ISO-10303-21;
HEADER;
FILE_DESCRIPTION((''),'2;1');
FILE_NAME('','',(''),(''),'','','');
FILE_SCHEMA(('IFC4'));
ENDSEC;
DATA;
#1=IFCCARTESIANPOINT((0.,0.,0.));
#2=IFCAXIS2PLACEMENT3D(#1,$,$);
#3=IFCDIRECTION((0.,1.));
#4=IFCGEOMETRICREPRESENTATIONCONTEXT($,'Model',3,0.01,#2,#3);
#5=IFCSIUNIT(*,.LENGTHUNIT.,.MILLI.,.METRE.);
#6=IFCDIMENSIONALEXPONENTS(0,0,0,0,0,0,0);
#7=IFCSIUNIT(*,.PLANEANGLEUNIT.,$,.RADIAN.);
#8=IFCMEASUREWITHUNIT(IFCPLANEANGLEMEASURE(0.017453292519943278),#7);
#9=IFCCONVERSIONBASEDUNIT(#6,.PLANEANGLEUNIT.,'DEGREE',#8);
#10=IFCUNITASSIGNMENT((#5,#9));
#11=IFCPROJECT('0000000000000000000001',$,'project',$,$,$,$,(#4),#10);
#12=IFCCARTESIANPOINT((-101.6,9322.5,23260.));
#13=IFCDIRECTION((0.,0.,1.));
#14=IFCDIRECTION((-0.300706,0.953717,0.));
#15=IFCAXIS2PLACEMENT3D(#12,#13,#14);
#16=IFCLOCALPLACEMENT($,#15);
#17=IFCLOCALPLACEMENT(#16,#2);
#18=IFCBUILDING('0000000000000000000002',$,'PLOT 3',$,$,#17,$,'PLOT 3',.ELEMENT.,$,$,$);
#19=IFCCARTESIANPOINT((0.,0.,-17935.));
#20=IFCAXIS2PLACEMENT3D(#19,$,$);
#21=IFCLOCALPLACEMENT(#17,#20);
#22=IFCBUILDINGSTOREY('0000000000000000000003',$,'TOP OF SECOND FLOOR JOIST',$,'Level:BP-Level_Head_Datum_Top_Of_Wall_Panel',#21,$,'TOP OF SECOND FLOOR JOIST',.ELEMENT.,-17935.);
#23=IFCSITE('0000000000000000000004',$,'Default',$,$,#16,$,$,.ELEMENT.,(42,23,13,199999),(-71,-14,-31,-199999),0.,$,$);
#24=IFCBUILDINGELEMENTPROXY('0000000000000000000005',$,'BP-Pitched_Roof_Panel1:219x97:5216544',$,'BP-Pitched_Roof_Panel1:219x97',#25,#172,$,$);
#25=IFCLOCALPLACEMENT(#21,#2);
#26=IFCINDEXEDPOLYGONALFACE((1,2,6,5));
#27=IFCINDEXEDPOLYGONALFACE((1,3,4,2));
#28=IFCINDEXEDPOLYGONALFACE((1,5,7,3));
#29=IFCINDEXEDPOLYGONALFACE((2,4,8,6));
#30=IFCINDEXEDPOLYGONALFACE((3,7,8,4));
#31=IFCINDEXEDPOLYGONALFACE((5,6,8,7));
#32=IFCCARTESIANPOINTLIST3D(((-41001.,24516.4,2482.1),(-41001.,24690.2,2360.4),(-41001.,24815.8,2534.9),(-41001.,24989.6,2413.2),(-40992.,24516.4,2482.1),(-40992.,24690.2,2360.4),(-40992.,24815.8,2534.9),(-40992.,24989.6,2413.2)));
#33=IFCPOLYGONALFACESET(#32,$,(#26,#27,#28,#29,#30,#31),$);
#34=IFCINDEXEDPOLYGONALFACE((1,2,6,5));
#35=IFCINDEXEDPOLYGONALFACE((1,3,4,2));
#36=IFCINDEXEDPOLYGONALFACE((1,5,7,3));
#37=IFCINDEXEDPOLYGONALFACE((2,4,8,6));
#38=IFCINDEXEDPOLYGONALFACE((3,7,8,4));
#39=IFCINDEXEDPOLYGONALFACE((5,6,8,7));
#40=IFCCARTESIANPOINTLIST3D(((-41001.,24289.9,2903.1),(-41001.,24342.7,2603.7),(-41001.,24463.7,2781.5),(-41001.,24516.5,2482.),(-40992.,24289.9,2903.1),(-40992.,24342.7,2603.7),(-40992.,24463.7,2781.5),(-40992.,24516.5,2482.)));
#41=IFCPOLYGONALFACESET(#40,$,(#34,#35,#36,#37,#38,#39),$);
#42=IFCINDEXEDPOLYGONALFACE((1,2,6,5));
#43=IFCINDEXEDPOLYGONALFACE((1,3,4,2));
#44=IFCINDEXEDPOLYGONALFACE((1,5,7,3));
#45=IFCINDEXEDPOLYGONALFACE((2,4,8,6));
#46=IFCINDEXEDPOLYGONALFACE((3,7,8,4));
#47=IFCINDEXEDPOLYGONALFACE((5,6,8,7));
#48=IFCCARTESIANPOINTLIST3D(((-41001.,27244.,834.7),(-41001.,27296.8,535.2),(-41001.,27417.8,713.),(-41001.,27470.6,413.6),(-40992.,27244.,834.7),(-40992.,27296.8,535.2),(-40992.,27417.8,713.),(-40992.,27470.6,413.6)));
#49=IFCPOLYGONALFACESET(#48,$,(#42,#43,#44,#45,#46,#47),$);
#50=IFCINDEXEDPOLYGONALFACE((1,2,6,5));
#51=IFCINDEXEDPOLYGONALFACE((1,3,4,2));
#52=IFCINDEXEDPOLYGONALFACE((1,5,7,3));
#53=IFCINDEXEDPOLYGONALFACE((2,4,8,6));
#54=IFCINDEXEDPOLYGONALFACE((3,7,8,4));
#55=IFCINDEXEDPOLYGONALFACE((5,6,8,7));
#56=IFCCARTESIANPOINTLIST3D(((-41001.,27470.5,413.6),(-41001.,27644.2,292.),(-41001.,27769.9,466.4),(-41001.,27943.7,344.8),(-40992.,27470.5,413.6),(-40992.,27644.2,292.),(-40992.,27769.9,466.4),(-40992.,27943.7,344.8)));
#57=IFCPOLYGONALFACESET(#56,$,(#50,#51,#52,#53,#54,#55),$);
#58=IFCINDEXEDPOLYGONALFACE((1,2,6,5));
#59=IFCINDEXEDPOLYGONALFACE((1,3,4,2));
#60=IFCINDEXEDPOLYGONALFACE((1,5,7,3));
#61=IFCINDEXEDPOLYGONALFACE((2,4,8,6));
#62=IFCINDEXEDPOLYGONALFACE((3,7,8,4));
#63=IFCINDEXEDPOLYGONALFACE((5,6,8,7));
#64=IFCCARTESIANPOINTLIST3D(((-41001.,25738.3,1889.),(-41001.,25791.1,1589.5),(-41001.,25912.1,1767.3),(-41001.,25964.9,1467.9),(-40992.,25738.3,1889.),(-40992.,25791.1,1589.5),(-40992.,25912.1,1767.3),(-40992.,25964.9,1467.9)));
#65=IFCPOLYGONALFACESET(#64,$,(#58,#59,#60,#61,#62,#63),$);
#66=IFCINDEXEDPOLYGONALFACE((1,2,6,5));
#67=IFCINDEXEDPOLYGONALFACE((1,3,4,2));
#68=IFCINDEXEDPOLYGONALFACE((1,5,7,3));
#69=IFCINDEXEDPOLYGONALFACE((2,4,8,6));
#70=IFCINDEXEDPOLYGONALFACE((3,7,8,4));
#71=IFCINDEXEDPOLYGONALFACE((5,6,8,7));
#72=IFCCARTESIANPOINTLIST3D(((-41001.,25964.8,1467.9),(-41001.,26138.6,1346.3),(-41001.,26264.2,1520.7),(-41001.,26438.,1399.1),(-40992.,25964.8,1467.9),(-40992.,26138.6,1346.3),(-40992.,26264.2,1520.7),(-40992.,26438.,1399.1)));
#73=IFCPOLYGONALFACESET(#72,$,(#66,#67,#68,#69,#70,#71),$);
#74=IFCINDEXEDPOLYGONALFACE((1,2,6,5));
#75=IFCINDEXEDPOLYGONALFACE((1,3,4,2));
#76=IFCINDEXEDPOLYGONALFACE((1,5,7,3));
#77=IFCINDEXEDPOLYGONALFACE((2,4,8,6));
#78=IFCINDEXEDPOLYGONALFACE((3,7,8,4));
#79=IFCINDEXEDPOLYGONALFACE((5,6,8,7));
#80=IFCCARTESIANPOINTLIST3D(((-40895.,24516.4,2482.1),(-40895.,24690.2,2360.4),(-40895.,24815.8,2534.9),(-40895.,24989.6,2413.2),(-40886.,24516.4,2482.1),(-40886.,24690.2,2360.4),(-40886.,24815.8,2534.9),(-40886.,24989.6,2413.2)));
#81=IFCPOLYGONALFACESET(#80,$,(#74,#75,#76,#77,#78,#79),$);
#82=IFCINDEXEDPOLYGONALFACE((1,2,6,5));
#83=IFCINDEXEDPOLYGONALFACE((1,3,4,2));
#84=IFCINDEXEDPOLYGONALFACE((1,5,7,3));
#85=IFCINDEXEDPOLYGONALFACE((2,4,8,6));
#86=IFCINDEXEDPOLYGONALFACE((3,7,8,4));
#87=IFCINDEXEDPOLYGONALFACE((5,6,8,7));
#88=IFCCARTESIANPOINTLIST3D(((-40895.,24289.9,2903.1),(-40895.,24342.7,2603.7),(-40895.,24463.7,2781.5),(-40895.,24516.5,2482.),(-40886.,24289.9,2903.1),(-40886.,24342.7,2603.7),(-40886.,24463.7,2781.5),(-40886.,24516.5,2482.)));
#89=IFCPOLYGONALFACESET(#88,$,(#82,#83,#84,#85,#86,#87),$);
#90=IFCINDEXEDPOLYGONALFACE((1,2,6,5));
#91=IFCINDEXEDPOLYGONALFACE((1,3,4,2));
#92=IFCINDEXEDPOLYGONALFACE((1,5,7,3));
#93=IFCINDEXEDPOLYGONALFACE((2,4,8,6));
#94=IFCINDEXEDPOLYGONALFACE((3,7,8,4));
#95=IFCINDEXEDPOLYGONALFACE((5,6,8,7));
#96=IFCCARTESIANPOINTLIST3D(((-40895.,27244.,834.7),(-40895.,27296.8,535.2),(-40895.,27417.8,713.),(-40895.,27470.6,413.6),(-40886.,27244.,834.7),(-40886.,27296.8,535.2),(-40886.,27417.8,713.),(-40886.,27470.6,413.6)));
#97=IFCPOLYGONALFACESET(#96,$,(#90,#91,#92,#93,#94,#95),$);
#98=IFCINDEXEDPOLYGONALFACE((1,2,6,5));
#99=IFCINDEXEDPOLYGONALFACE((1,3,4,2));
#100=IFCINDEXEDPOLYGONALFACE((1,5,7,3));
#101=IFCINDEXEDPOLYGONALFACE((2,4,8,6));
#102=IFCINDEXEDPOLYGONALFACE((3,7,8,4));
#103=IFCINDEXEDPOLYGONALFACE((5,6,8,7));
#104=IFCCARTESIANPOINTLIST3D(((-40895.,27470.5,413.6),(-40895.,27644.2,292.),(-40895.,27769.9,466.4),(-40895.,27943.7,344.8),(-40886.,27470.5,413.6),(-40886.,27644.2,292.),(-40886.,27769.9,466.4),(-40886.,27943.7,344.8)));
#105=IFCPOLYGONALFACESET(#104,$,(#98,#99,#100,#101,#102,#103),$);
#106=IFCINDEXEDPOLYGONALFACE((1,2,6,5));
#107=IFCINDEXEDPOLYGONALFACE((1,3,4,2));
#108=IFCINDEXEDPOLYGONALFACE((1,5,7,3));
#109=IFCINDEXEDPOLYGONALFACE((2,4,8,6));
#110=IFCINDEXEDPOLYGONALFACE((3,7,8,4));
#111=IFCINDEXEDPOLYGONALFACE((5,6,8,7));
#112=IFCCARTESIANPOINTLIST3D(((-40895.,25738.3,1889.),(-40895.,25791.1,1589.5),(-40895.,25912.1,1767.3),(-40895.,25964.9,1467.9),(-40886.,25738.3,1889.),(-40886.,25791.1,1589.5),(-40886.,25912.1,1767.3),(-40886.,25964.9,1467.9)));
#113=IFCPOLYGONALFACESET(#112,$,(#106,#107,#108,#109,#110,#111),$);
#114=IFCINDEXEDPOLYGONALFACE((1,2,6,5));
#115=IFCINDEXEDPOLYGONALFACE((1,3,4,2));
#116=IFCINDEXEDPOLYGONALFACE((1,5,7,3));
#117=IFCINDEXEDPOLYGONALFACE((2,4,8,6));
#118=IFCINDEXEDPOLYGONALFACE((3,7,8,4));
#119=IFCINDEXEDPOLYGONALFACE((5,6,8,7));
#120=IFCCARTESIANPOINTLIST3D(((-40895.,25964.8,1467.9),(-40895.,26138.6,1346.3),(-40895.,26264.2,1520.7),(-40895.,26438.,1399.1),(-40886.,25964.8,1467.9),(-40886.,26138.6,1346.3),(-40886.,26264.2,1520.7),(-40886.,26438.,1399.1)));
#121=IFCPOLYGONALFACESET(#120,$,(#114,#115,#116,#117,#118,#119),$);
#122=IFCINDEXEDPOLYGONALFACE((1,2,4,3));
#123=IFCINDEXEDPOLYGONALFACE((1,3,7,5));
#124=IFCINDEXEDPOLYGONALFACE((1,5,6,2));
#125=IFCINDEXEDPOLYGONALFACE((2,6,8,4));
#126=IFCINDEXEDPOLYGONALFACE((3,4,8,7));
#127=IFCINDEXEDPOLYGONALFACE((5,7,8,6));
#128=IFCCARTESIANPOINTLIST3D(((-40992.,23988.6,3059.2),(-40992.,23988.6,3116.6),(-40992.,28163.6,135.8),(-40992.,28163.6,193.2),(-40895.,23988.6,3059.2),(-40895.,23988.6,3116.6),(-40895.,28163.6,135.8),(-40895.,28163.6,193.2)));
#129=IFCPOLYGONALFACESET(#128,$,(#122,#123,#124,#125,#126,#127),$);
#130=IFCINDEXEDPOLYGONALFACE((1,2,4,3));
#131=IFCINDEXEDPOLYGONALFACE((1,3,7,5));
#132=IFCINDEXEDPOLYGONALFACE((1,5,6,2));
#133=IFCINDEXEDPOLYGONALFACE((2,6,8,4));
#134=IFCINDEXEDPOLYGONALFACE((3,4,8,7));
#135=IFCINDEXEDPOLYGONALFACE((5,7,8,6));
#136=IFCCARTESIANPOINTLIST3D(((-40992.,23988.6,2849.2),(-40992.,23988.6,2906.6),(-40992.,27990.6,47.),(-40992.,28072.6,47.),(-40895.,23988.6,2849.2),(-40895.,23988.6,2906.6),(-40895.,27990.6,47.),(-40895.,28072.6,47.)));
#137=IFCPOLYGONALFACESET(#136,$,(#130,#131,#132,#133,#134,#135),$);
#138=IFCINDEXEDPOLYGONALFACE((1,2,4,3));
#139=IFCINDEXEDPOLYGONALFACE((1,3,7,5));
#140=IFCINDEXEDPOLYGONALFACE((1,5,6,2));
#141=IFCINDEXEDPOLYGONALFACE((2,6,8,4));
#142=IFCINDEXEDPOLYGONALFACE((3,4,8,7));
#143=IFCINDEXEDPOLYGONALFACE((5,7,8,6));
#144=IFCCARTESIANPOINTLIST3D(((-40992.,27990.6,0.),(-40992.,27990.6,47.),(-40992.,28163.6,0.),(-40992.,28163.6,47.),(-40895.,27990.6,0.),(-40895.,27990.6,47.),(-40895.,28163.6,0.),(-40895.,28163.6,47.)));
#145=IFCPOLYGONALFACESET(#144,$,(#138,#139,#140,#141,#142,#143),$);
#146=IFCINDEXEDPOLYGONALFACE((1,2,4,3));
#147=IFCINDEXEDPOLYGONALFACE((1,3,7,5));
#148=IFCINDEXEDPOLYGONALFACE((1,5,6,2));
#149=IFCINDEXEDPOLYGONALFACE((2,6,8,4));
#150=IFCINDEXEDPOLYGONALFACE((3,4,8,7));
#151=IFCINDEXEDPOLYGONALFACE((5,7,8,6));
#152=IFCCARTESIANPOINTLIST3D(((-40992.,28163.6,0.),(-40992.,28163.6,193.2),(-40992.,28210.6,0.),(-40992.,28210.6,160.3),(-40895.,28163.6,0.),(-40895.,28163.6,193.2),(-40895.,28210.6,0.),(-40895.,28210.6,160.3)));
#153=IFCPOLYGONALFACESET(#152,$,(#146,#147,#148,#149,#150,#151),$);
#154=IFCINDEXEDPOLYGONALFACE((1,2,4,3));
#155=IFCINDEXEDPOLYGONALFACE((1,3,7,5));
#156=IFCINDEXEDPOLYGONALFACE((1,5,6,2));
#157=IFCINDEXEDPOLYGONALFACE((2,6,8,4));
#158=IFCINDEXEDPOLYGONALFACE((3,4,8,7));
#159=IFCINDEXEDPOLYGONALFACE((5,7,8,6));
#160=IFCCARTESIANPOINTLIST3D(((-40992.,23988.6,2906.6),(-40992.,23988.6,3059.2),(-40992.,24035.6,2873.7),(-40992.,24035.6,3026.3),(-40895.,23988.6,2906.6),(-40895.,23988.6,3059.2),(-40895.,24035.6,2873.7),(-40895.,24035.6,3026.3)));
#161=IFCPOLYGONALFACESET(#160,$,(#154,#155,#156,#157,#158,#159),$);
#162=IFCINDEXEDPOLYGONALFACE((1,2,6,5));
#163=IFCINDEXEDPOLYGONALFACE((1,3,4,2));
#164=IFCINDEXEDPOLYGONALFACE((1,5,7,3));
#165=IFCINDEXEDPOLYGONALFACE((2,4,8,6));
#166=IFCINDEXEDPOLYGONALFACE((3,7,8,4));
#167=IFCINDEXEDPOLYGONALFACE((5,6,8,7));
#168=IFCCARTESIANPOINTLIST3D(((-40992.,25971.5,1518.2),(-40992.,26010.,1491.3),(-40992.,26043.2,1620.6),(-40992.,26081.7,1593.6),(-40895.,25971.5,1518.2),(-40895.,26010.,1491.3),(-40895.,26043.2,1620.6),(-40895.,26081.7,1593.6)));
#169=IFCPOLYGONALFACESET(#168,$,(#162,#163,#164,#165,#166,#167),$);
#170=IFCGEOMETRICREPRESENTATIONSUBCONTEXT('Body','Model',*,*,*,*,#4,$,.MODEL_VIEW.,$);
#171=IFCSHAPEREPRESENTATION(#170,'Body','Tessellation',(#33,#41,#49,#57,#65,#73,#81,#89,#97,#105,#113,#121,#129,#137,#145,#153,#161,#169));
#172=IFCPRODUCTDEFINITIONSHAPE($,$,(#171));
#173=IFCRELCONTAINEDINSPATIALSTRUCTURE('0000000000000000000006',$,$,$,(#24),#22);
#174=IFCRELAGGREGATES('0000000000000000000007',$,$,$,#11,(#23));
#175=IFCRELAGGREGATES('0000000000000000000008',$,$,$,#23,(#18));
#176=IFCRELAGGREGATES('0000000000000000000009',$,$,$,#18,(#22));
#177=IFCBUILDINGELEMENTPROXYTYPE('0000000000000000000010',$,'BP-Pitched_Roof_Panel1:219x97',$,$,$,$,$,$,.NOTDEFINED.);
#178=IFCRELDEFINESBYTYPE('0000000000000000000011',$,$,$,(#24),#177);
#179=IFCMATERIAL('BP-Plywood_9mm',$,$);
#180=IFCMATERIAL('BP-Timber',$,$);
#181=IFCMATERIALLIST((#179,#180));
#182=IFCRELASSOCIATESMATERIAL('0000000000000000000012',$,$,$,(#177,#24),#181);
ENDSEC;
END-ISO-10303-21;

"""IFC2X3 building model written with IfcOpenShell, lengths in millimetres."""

from ifc_helpers import new_model, entity, si_unit, converted_unit, direction, frame, frame_2d, origin, origin_2d_with_axis, place, context, subcontext, project, spatial, polyline, rectangle, outline, extrude, source, transform, mapped, material, material_list, type_object, type_shapes, element, save


model = new_model("IFC2X3")

# Units and contexts
model_context = context("Model", 3, precision=0.01, world=origin(), true_north=direction((0.0, 1.0)))
body_context = subcontext(model_context, "Body", "Model", "MODEL_VIEW")
ifc_project = project(units=[si_unit("LENGTHUNIT", "METRE", prefix="MILLI"), converted_unit("PLANEANGLEUNIT", "DEGREE", entity("IfcPlaneAngleMeasure", 0.017453292519943278), si_unit("PLANEANGLEUNIT", "RADIAN"), dimensions=[0, 0, 0, 0, 0, 0, 0])], contexts=[model_context])

# Site, building, storey
site_placement = place(None, frame((-101.6, 9322.5, 23260.0), z_axis=(0.0, 0.0, 1.0), x_axis=(-0.300706, 0.953717, 0.0)))
site = spatial("IfcSite", under=ifc_project, at=site_placement, Name="Default", CompositionType="ELEMENT", RefLatitude=(42, 23, 13, 199999), RefLongitude=(-71, -14, -31, -199999), RefElevation=0.0)
building_placement = place(site_placement, origin())
building = spatial("IfcBuilding", under=site, at=building_placement, Name="PLOT 3", LongName="PLOT 3", CompositionType="ELEMENT")
storey_placement = place(building_placement, frame((0.0, 0.0, -17935.0)))
storey = spatial("IfcBuildingStorey", under=building, at=storey_placement, Name="TOP OF SECOND FLOOR JOIST", ObjectType="Level:BP-Level_Head_Datum_Top_Of_Wall_Panel", LongName="TOP OF SECOND FLOOR JOIST", CompositionType="ELEMENT", Elevation=-17935.0)

# Building element proxy
ifc_material_1 = material(Name="BP-Timber")
ifc_material_2 = material(Name="BP-Plywood_9mm")
ifc_material_list = material_list([ifc_material_2, ifc_material_1])
building_element_proxy_type_1 = type_object("IfcBuildingElementProxyType", Name="BP-Pitched_Roof_Panel1:219x97", PredefinedType="NOTDEFINED", material=ifc_material_list)
shared_shape_1 = source(origin(), body_context, "Body", "SweptSolid", [
    extrude(outline(polyline([(-77.0, -75.0), (227.0, -75.0), (77.0, 75.0), (-227.0, 75.0), (-77.0, -75.0)])), frame((35.3, -3956.0, 2447.7), z_axis=(0.0, 1.0, 0.0), x_axis=(-0.984808, 0.0, 0.173648)), (0.0, 0.0, 1.0), 9.0),
    extrude(outline(polyline([(1.4, -107.5), (213.6, -107.5), (-1.4, 107.5), (-213.6, 107.5), (1.4, -107.5)])), frame((385.1, -3956.0, 2692.6), z_axis=(0.0, 1.0, 0.0), x_axis=(-0.819152, 0.0, -0.573576)), (0.0, 0.0, 1.0), 9.0),
    extrude(outline(polyline([(1.4, -107.5), (213.6, -107.5), (-1.4, 107.5), (-213.6, 107.5), (1.4, -107.5)])), frame((-2569.0, -3956.0, 624.1), z_axis=(0.0, 1.0, 0.0), x_axis=(-0.819152, 0.0, -0.573576)), (0.0, 0.0, 1.0), 9.0),
    extrude(outline(polyline([(-77.0, -75.0), (227.0, -75.0), (77.0, 75.0), (-227.0, 75.0), (-77.0, -75.0)])), frame((-2918.8, -3956.0, 379.2), z_axis=(0.0, 1.0, 0.0), x_axis=(-0.984808, 0.0, 0.173648)), (0.0, 0.0, 1.0), 9.0),
    extrude(outline(polyline([(1.4, -107.5), (213.6, -107.5), (-1.4, 107.5), (-213.6, 107.5), (1.4, -107.5)])), frame((-1063.3, -3956.0, 1678.4), z_axis=(0.0, 1.0, 0.0), x_axis=(-0.819152, 0.0, -0.573576)), (0.0, 0.0, 1.0), 9.0),
    extrude(outline(polyline([(-77.0, -75.0), (227.0, -75.0), (77.0, 75.0), (-227.0, 75.0), (-77.0, -75.0)])), frame((-1413.1, -3956.0, 1433.5), z_axis=(0.0, 1.0, 0.0), x_axis=(-0.984808, 0.0, 0.173648)), (0.0, 0.0, 1.0), 9.0),
    extrude(outline(polyline([(-77.0, -75.0), (227.0, -75.0), (77.0, 75.0), (-227.0, 75.0), (-77.0, -75.0)])), frame((35.3, -3850.0, 2447.7), z_axis=(0.0, 1.0, 0.0), x_axis=(-0.984808, 0.0, 0.173648)), (0.0, 0.0, 1.0), 9.0),
    extrude(outline(polyline([(1.4, -107.5), (213.6, -107.5), (-1.4, 107.5), (-213.6, 107.5), (1.4, -107.5)])), frame((385.1, -3850.0, 2692.6), z_axis=(0.0, 1.0, 0.0), x_axis=(-0.819152, 0.0, -0.573576)), (0.0, 0.0, 1.0), 9.0),
    extrude(outline(polyline([(1.4, -107.5), (213.6, -107.5), (-1.4, 107.5), (-213.6, 107.5), (1.4, -107.5)])), frame((-2569.0, -3850.0, 624.1), z_axis=(0.0, 1.0, 0.0), x_axis=(-0.819152, 0.0, -0.573576)), (0.0, 0.0, 1.0), 9.0),
    extrude(outline(polyline([(-77.0, -75.0), (227.0, -75.0), (77.0, 75.0), (-227.0, 75.0), (-77.0, -75.0)])), frame((-2918.8, -3850.0, 379.2), z_axis=(0.0, 1.0, 0.0), x_axis=(-0.984808, 0.0, 0.173648)), (0.0, 0.0, 1.0), 9.0),
    extrude(outline(polyline([(1.4, -107.5), (213.6, -107.5), (-1.4, 107.5), (-213.6, 107.5), (1.4, -107.5)])), frame((-1063.3, -3850.0, 1678.4), z_axis=(0.0, 1.0, 0.0), x_axis=(-0.819152, 0.0, -0.573576)), (0.0, 0.0, 1.0), 9.0),
    extrude(outline(polyline([(-77.0, -75.0), (227.0, -75.0), (77.0, 75.0), (-227.0, 75.0), (-77.0, -75.0)])), frame((-1413.1, -3850.0, 1433.5), z_axis=(0.0, 1.0, 0.0), x_axis=(-0.984808, 0.0, 0.173648)), (0.0, 0.0, 1.0), 9.0),
    extrude(outline(polyline([(-1490.4, -2087.5), (-1433.0, -2087.5), (1490.4, 2087.5), (1433.0, 2087.5), (-1490.4, -2087.5)])), frame((-1287.8, -3947.0, 1626.2), z_axis=(0.0, 1.0, 0.0), x_axis=(0.0, 0.0, -1.0)), (0.0, 0.0, 1.0), 97.0),
    extrude(outline(polyline([(-1444.1, -2021.5), (-1386.8, -2021.5), (1415.5, 1980.5), (1415.5, 2062.5), (-1444.1, -2021.5)])), frame((-1221.8, -3947.0, 1462.5), z_axis=(0.0, 1.0, 0.0), x_axis=(0.0, 0.0, -1.0)), (0.0, 0.0, 1.0), 97.0),
    extrude(rectangle(XDim=173.0, YDim=97.0, at=origin_2d_with_axis()), frame((-3288.8, -3898.5, 0.0), z_axis=(0.0, 0.0, 1.0), x_axis=(-1.0, 0.0, 0.0)), (0.0, 0.0, 1.0), 47.0),
    extrude(outline(polyline([(22.0, -72.4), (79.4, -72.4), (-31.4, 85.9), (-69.9, 58.9), (22.0, -72.4)])), frame((-3398.8, -3947.0, 88.4), z_axis=(0.0, 1.0, 0.0), x_axis=(0.819152, 0.0, 0.573576)), (0.0, 0.0, 1.0), 97.0),
    extrude(outline(polyline([(15.1, -62.5), (72.5, -62.5), (-15.1, 62.5), (-72.5, 62.5), (15.1, -62.5)])), frame((776.2, -3947.0, 2966.5), z_axis=(0.0, 1.0, 0.0), x_axis=(0.819152, 0.0, 0.573576)), (0.0, 0.0, 1.0), 97.0),
    extrude(rectangle(XDim=47.0, YDim=97.0, at=frame_2d((0.0, 0.0), x_axis=(1.0, 0.0))), frame((-1202.4, -3898.5, 1504.7), z_axis=(-0.573576, 0.0, 0.819152), x_axis=(-0.819152, 0.0, -0.573576)), (0.0, 0.0, 1.0), 125.0),
])
type_shapes(building_element_proxy_type_1, [shared_shape_1])
for number, where, z_axis, x_axis, name in (
    (1, (-37045.0, 24788.3, 0.0), (0.0, 0.0, 1.0), (0.0, -1.0, 0.0), "BP-Pitched_Roof_Panel1:219x97:5216544"),
):
    element("IfcBuildingElementProxy", number, at=place(storey_placement, frame(where, z_axis=z_axis, x_axis=x_axis)), inside=storey, type_object=building_element_proxy_type_1, material=ifc_material_list, Name=name, ObjectType="BP-Pitched_Roof_Panel1:219x97", context=body_context, shape_type="MappedRepresentation", body=[
        mapped(shared_shape_1, transform((0.0, 0.0, 0.0), scale=1.0)),
    ])

save(model, "model.ifc")
